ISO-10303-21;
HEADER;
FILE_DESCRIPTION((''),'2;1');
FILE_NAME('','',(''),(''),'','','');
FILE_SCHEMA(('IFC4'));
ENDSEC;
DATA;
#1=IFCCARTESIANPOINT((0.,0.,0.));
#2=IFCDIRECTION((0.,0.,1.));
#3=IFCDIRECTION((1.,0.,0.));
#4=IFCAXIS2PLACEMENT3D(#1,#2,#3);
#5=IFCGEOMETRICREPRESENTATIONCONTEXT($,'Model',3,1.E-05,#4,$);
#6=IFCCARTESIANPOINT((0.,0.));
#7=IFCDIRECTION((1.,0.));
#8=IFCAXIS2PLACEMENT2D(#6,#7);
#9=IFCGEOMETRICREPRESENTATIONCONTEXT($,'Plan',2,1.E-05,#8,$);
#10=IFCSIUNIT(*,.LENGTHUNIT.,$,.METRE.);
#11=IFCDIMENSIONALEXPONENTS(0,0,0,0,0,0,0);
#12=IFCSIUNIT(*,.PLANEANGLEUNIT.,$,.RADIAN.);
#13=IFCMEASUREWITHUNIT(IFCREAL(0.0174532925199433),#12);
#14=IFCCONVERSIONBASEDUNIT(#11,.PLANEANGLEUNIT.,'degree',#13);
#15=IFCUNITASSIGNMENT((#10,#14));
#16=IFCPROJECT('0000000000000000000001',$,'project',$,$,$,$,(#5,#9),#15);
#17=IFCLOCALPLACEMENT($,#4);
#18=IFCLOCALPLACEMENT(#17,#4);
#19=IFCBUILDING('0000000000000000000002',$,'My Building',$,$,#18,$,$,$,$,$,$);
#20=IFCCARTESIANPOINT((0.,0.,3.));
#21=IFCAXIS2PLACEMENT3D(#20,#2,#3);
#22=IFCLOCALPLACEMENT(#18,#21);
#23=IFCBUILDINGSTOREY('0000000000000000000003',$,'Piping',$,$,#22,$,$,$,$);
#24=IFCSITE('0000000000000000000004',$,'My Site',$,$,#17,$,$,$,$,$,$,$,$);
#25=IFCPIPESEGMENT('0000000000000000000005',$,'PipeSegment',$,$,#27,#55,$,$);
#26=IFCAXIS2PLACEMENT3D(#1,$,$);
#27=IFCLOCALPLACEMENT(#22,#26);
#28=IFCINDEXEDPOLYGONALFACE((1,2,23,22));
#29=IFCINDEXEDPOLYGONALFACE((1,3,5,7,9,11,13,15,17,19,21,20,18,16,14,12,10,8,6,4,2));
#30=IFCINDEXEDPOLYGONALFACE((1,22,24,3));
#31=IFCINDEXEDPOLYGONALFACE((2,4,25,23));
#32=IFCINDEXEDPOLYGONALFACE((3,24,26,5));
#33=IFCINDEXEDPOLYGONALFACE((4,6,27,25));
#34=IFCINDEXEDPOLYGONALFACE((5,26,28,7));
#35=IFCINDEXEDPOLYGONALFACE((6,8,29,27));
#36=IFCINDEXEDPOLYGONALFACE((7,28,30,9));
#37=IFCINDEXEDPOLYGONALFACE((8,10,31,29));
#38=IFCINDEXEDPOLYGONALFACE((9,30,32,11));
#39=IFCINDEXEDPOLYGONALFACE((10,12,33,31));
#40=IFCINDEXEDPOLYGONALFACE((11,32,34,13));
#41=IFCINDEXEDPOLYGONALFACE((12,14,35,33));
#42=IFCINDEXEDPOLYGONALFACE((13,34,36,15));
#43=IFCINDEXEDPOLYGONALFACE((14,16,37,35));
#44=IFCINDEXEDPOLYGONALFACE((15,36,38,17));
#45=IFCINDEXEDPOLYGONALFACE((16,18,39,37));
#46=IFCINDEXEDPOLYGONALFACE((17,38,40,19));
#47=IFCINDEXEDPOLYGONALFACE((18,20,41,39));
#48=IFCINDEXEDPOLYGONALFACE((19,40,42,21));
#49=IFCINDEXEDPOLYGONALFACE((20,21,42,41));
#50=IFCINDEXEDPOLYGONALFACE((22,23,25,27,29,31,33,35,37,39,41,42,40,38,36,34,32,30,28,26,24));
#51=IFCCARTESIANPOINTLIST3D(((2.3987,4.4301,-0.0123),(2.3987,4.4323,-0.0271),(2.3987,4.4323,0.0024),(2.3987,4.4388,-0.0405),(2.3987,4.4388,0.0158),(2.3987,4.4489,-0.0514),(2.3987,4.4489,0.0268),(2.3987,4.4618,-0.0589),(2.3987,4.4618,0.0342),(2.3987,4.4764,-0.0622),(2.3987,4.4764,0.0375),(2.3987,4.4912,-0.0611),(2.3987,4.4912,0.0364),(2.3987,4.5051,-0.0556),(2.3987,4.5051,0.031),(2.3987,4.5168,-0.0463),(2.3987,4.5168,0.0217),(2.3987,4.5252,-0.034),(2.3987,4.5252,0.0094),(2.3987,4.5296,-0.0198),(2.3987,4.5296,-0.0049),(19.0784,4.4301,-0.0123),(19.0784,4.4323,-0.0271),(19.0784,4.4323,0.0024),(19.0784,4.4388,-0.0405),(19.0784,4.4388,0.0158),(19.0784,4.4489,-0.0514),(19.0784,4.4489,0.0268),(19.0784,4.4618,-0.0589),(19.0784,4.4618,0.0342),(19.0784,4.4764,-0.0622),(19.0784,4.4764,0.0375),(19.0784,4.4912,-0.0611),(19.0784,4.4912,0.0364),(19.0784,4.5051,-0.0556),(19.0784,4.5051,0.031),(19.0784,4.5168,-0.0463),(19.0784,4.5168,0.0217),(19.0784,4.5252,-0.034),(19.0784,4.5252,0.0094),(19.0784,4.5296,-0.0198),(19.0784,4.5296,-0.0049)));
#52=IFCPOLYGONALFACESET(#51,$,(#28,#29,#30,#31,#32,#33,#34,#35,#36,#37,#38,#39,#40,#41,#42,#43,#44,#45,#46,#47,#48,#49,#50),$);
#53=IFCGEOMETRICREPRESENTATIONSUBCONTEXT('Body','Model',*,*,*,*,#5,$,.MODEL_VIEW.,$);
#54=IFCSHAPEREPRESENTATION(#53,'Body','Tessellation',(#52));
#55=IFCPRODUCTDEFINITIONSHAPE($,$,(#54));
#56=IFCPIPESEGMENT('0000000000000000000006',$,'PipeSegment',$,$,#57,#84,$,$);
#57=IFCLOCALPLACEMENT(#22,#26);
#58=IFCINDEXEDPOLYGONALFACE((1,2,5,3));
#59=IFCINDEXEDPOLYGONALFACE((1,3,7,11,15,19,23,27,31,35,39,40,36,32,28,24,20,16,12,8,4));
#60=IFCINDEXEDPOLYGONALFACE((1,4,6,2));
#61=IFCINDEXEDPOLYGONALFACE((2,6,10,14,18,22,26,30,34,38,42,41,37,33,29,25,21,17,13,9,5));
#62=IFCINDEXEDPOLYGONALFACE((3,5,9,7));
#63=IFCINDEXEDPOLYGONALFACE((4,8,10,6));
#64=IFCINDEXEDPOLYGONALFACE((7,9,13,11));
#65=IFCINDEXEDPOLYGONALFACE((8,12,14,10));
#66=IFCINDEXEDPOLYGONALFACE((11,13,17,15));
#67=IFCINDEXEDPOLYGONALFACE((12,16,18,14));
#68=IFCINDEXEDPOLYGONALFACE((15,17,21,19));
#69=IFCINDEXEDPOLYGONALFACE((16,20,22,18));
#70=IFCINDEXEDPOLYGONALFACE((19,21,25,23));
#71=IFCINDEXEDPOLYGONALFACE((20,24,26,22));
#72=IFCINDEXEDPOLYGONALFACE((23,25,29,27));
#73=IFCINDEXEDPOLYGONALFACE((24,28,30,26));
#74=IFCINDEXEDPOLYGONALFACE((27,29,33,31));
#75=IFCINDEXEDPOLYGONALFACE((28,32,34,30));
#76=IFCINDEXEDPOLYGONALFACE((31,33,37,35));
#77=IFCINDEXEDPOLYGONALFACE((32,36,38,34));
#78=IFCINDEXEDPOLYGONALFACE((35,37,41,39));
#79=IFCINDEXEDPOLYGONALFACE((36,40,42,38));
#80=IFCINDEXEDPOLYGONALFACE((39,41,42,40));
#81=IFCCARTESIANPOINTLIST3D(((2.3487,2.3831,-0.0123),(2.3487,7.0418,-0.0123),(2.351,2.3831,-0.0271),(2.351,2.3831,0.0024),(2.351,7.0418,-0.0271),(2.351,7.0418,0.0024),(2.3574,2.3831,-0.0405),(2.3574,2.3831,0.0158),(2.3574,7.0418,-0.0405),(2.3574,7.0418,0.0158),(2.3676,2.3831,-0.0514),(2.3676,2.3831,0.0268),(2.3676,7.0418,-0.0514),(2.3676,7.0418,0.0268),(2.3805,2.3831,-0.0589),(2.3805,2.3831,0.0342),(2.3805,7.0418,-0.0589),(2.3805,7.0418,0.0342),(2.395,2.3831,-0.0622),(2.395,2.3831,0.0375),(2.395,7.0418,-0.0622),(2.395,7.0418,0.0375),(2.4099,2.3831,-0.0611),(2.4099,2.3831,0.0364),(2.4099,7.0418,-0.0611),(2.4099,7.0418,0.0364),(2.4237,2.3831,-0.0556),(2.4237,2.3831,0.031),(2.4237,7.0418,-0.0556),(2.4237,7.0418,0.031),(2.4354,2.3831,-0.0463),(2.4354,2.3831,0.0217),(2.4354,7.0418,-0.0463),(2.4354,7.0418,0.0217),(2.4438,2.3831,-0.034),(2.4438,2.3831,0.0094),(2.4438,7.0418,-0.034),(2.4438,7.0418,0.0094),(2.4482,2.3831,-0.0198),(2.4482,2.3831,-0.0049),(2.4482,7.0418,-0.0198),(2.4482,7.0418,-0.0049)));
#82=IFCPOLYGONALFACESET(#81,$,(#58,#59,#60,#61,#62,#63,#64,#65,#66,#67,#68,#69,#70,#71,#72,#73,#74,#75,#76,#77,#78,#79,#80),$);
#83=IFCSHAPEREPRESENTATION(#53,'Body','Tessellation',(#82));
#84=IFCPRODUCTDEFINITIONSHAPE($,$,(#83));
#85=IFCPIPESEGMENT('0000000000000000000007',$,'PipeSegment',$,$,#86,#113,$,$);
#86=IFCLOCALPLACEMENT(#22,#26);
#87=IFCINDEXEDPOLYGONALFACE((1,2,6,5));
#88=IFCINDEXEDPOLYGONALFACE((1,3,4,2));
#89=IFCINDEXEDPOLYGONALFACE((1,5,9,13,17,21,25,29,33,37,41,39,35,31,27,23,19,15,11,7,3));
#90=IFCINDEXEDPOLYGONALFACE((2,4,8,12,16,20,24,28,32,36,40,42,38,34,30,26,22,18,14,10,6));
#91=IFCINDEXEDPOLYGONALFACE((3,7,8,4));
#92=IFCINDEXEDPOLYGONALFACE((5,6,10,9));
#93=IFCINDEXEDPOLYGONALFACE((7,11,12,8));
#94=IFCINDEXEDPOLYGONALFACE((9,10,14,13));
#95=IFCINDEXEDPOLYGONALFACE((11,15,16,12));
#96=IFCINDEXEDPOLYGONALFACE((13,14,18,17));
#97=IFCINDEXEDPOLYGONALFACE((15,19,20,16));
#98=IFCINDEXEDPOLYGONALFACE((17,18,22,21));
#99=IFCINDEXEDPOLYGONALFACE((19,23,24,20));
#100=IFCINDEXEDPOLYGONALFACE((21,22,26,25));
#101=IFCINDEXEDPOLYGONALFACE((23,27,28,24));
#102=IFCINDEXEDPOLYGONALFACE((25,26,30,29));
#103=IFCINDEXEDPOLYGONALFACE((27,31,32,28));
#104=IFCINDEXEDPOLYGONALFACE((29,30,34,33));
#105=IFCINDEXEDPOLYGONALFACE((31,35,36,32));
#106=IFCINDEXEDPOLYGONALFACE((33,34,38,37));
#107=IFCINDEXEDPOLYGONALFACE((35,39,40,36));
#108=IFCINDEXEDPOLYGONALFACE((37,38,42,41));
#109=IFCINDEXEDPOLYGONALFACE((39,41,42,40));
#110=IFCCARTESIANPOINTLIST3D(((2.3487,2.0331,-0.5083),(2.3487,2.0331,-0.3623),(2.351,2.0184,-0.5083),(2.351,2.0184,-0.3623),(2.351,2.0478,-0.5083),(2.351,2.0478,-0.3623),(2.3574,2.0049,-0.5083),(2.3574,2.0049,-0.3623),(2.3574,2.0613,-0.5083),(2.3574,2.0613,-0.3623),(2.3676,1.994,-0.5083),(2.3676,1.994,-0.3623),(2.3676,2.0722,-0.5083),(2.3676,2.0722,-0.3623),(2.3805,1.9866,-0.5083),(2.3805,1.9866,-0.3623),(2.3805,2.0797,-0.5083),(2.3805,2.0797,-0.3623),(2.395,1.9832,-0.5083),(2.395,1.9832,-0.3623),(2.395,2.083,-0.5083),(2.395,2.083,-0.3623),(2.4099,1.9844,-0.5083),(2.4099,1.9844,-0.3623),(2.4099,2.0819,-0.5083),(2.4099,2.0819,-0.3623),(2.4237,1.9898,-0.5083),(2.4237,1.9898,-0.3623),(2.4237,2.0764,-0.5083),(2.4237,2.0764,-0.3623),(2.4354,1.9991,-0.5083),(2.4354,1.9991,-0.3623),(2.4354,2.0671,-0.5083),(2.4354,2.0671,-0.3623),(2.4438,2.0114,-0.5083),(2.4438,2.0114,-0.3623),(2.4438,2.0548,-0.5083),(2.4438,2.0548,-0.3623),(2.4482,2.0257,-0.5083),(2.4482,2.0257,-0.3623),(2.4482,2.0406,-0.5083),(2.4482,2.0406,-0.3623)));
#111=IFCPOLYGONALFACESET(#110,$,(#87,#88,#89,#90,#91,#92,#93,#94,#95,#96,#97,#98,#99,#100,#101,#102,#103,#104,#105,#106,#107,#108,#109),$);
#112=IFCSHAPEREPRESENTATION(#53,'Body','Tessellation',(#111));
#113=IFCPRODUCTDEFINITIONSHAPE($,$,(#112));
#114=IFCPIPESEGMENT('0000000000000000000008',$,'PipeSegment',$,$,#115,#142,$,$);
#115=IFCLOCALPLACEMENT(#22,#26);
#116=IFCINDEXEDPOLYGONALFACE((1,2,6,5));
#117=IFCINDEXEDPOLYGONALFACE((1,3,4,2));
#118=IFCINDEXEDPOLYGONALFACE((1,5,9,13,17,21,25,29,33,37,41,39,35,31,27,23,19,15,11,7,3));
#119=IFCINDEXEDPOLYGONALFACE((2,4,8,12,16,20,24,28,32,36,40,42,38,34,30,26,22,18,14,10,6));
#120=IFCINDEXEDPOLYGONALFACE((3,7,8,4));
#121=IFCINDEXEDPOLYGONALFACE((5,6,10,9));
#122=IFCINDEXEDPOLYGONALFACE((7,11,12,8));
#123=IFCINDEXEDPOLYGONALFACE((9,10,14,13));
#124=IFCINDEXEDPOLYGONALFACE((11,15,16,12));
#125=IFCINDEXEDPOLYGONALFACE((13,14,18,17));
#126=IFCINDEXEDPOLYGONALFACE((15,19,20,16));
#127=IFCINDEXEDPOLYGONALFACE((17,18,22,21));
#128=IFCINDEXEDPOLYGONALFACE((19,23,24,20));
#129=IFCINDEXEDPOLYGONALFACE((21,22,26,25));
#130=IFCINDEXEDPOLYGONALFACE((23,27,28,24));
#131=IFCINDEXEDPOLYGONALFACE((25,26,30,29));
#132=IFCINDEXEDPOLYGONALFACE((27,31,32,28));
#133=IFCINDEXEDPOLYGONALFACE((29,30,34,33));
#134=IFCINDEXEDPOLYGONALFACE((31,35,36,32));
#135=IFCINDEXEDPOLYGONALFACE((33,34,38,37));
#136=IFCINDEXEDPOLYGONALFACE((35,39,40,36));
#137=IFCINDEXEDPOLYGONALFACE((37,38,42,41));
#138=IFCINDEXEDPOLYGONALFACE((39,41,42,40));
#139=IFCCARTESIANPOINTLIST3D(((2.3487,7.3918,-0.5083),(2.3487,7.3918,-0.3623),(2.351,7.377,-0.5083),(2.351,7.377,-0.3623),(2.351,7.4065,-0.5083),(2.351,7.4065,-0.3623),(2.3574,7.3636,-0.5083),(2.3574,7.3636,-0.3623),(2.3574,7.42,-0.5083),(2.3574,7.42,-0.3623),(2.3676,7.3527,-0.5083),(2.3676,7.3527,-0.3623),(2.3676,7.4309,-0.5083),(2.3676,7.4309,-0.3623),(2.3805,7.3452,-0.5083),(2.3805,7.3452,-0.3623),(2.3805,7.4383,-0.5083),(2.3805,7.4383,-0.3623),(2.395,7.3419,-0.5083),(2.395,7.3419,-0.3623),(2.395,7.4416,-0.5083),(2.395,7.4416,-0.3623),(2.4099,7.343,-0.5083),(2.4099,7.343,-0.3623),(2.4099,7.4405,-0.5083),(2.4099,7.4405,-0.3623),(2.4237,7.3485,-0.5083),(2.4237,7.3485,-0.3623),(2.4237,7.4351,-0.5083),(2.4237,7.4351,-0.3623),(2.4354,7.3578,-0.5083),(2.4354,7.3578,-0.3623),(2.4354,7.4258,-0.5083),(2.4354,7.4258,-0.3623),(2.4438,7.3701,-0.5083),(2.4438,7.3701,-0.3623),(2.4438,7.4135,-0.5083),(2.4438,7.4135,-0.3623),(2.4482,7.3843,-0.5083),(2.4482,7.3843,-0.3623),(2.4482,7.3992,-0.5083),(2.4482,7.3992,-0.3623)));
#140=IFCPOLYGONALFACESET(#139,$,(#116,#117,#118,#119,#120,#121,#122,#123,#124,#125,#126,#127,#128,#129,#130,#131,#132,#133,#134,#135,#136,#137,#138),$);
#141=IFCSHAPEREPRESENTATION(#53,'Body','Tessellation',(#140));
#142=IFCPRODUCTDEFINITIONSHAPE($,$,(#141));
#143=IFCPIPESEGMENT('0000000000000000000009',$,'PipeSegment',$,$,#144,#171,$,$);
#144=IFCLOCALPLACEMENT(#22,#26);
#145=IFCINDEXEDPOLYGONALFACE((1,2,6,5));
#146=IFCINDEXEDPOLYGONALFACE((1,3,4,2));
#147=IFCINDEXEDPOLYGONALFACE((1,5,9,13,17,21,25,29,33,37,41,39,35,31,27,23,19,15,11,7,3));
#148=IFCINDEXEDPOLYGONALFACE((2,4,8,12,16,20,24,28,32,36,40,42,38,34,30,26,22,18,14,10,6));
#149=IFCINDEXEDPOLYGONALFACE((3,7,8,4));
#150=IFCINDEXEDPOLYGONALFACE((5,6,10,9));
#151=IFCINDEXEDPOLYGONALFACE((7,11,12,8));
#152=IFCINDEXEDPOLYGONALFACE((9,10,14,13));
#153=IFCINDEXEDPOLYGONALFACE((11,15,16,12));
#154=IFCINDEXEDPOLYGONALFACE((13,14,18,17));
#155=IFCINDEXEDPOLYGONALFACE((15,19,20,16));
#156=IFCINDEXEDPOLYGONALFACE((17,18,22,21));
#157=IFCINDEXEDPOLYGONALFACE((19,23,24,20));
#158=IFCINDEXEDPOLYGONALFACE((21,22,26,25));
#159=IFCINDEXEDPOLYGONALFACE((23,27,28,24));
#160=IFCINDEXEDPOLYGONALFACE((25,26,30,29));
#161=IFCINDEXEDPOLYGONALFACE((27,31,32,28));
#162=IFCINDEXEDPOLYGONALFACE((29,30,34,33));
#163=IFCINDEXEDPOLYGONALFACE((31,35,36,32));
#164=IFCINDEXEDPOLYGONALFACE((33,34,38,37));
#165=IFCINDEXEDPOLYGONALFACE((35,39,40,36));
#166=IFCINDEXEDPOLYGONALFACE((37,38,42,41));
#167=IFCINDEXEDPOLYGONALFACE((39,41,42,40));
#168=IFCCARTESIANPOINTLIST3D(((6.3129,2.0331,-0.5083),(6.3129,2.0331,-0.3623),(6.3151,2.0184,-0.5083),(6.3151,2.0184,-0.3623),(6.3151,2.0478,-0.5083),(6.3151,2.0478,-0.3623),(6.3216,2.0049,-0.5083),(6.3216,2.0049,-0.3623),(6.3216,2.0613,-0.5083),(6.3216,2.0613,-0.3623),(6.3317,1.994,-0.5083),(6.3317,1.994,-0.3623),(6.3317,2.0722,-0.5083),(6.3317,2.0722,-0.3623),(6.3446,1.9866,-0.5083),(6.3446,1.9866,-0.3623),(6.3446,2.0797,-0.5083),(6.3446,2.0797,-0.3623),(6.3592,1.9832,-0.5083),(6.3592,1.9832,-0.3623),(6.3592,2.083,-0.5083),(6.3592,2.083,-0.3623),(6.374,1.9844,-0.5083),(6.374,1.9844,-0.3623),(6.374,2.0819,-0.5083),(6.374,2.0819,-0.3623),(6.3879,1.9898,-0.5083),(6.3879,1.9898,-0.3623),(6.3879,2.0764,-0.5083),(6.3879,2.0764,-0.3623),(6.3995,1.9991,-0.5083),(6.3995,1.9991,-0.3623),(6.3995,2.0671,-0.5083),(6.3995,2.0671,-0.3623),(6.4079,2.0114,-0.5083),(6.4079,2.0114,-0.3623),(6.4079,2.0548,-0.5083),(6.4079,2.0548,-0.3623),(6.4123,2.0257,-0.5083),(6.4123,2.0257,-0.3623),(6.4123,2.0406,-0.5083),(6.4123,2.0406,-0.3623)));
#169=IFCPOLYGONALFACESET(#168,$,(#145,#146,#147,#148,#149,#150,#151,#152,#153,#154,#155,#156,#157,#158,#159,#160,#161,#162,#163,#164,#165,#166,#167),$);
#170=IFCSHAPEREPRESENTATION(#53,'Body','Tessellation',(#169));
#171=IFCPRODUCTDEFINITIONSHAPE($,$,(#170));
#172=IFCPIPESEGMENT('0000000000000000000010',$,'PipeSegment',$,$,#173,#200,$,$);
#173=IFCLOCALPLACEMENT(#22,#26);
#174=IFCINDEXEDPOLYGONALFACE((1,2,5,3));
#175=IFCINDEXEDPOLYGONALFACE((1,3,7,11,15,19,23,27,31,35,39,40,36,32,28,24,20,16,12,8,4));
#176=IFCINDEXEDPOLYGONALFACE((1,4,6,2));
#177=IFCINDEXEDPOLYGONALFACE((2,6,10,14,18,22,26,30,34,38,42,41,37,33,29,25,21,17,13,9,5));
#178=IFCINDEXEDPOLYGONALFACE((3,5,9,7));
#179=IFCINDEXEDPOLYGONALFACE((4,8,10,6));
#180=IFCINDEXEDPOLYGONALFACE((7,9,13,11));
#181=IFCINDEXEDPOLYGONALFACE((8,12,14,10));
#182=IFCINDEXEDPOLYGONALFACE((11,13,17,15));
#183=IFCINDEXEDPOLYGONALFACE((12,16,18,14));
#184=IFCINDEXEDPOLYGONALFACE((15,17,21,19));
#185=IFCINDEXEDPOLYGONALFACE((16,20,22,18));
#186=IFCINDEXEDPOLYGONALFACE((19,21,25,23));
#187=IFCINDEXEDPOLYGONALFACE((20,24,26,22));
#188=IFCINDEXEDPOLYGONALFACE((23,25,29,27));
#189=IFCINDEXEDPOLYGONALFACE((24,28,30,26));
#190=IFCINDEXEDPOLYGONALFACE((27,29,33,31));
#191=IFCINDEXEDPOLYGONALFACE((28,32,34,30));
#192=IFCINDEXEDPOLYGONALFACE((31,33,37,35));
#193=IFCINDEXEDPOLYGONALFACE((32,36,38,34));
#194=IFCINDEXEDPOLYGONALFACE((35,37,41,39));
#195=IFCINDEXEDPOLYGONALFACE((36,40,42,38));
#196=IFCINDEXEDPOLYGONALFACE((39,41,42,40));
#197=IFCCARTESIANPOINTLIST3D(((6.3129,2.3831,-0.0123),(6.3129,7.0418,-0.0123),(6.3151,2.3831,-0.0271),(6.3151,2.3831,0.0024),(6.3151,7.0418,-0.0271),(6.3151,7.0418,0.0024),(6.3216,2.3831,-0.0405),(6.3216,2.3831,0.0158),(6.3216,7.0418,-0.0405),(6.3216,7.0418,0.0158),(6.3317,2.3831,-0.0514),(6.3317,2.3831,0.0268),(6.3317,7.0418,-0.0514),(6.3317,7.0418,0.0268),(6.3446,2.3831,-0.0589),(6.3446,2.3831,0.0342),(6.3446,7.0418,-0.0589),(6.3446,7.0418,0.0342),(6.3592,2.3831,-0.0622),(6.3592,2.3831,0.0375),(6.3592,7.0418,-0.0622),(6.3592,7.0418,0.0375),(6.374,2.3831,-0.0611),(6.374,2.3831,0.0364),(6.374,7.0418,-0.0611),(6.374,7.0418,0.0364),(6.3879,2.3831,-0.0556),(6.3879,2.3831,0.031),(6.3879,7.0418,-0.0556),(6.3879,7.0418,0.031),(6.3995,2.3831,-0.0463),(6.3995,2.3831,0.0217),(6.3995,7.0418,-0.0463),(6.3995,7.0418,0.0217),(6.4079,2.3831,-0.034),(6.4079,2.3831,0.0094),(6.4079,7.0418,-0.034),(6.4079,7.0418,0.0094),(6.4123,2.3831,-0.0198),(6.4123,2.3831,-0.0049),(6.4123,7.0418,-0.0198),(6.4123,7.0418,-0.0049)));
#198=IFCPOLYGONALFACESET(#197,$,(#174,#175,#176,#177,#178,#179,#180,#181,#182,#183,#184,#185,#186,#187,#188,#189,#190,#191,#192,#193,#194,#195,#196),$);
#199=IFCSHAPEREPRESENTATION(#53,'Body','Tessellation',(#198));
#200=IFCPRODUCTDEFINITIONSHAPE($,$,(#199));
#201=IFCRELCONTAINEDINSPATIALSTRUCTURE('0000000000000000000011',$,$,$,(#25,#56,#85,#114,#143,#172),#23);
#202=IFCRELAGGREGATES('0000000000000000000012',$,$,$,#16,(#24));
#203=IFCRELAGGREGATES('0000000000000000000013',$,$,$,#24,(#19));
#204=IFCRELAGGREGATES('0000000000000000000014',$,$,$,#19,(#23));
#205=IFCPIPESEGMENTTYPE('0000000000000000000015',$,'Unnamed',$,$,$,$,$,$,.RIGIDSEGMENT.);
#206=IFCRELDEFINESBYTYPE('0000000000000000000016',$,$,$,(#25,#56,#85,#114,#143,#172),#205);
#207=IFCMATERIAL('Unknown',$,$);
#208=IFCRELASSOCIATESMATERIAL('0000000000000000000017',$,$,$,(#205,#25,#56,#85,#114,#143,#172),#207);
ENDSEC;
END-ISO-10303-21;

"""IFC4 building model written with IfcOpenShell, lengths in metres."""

from ifc_helpers import new_model, entity, si_unit, converted_unit, frame, origin_with_axes, origin_2d_with_axis, place, context, subcontext, project, spatial, circle, extrude, material, material_profile, profile_set, profile_usage, type_object, element, save


model = new_model("IFC4")

# Units and contexts
model_context = context("Model", 3, precision=1e-05, world=origin_with_axes())
plan_context = context("Plan", 2, precision=1e-05, world=origin_2d_with_axis())
body_context = subcontext(model_context, "Body", "Model", "MODEL_VIEW")
ifc_project = project(units=[si_unit("LENGTHUNIT", "METRE"), converted_unit("PLANEANGLEUNIT", "degree", entity("IfcReal", 0.0174532925199433), si_unit("PLANEANGLEUNIT", "RADIAN"), dimensions=[0, 0, 0, 0, 0, 0, 0])], contexts=[model_context, plan_context])

# Site, building, storey
site_placement = place(None, origin_with_axes())
site = spatial("IfcSite", under=ifc_project, at=site_placement, Name="My Site")
building_placement = place(site_placement, origin_with_axes())
building = spatial("IfcBuilding", under=site, at=building_placement, Name="My Building")
storey_placement = place(building_placement, frame((0.0, 0.0, 3.0), z_axis=(0.0, 0.0, 1.0), x_axis=(1.0, 0.0, 0.0)))
storey = spatial("IfcBuildingStorey", under=building, at=storey_placement, Name="Piping")

# Pipe segments
ifc_material = material(Name="Unknown")
ifc_material_profile = material_profile(ifc_material, circle(Radius=0.05))
ifc_profile_set = profile_set([ifc_material_profile])
ifc_profile_usage_1 = profile_usage(ifc_profile_set, cardinal=5)
pipe_segment_type = type_object("IfcPipeSegmentType", Name="Unnamed", PredefinedType="RIGIDSEGMENT", material=ifc_profile_set)
pipe_segment_1_placement = place(storey_placement, frame((19.0784, 4.4801, -0.0123), z_axis=(-1.0, 0.0, 0.0), x_axis=(0.0, -1.0, 0.0)))
element("IfcPipeSegment", 1, at=pipe_segment_1_placement, inside=storey, type_object=pipe_segment_type, material=ifc_profile_usage_1, Name="PipeSegment", context=body_context, shape_type="SweptSolid", body=[
    extrude(circle(Radius=0.05), origin_with_axes(), (0.0, 0.0, 1.0), 16.6797),
])
ifc_profile_usage_2 = profile_usage(ifc_profile_set, cardinal=5)
pipe_segment_2_placement = place(storey_placement, frame((2.3987, 2.3831, -0.0123), z_axis=(0.0, 1.0, 0.0), x_axis=(-1.0, 0.0, 0.0)))
element("IfcPipeSegment", 2, at=pipe_segment_2_placement, inside=storey, type_object=pipe_segment_type, material=ifc_profile_usage_2, Name="PipeSegment", context=body_context, shape_type="SweptSolid", body=[
    extrude(circle(Radius=0.05), origin_with_axes(), (0.0, 0.0, 1.0), 4.6587),
])
ifc_profile_usage_3 = profile_usage(ifc_profile_set, cardinal=5)
pipe_segment_3_placement = place(storey_placement, frame((2.3987, 2.0331, -0.3623), z_axis=(0.0, 0.0, -1.0), x_axis=(-1.0, 0.0, 0.0)))
element("IfcPipeSegment", 3, at=pipe_segment_3_placement, inside=storey, type_object=pipe_segment_type, material=ifc_profile_usage_3, Name="PipeSegment", context=body_context, shape_type="SweptSolid", body=[
    extrude(circle(Radius=0.05), origin_with_axes(), (0.0, 0.0, 1.0), 0.1459),
])
ifc_profile_usage_4 = profile_usage(ifc_profile_set, cardinal=5)
pipe_segment_4_placement = place(storey_placement, frame((2.3987, 7.3918, -0.3623), z_axis=(0.0, 0.0, -1.0), x_axis=(-1.0, 0.0, 0.0)))
element("IfcPipeSegment", 4, at=pipe_segment_4_placement, inside=storey, type_object=pipe_segment_type, material=ifc_profile_usage_4, Name="PipeSegment", context=body_context, shape_type="SweptSolid", body=[
    extrude(circle(Radius=0.05), origin_with_axes(), (0.0, 0.0, 1.0), 0.1459),
])
ifc_profile_usage_5 = profile_usage(ifc_profile_set, cardinal=5)
pipe_segment_5_placement = place(storey_placement, frame((6.3629, 2.0331, -0.3623), z_axis=(0.0, 0.0, -1.0), x_axis=(-1.0, 0.0, 0.0)))
element("IfcPipeSegment", 5, at=pipe_segment_5_placement, inside=storey, type_object=pipe_segment_type, material=ifc_profile_usage_5, Name="PipeSegment", context=body_context, shape_type="SweptSolid", body=[
    extrude(circle(Radius=0.05), origin_with_axes(), (0.0, 0.0, 1.0), 0.1459),
])
ifc_profile_usage_6 = profile_usage(ifc_profile_set, cardinal=5)
pipe_segment_6_placement = place(storey_placement, frame((6.3629, 2.3831, -0.0123), z_axis=(0.0, 1.0, 0.0), x_axis=(-1.0, 0.0, 0.0)))
element("IfcPipeSegment", 6, at=pipe_segment_6_placement, inside=storey, type_object=pipe_segment_type, material=ifc_profile_usage_6, Name="PipeSegment", context=body_context, shape_type="SweptSolid", body=[
    extrude(circle(Radius=0.05), origin_with_axes(), (0.0, 0.0, 1.0), 4.6587),
])

save(model, "model.ifc")
